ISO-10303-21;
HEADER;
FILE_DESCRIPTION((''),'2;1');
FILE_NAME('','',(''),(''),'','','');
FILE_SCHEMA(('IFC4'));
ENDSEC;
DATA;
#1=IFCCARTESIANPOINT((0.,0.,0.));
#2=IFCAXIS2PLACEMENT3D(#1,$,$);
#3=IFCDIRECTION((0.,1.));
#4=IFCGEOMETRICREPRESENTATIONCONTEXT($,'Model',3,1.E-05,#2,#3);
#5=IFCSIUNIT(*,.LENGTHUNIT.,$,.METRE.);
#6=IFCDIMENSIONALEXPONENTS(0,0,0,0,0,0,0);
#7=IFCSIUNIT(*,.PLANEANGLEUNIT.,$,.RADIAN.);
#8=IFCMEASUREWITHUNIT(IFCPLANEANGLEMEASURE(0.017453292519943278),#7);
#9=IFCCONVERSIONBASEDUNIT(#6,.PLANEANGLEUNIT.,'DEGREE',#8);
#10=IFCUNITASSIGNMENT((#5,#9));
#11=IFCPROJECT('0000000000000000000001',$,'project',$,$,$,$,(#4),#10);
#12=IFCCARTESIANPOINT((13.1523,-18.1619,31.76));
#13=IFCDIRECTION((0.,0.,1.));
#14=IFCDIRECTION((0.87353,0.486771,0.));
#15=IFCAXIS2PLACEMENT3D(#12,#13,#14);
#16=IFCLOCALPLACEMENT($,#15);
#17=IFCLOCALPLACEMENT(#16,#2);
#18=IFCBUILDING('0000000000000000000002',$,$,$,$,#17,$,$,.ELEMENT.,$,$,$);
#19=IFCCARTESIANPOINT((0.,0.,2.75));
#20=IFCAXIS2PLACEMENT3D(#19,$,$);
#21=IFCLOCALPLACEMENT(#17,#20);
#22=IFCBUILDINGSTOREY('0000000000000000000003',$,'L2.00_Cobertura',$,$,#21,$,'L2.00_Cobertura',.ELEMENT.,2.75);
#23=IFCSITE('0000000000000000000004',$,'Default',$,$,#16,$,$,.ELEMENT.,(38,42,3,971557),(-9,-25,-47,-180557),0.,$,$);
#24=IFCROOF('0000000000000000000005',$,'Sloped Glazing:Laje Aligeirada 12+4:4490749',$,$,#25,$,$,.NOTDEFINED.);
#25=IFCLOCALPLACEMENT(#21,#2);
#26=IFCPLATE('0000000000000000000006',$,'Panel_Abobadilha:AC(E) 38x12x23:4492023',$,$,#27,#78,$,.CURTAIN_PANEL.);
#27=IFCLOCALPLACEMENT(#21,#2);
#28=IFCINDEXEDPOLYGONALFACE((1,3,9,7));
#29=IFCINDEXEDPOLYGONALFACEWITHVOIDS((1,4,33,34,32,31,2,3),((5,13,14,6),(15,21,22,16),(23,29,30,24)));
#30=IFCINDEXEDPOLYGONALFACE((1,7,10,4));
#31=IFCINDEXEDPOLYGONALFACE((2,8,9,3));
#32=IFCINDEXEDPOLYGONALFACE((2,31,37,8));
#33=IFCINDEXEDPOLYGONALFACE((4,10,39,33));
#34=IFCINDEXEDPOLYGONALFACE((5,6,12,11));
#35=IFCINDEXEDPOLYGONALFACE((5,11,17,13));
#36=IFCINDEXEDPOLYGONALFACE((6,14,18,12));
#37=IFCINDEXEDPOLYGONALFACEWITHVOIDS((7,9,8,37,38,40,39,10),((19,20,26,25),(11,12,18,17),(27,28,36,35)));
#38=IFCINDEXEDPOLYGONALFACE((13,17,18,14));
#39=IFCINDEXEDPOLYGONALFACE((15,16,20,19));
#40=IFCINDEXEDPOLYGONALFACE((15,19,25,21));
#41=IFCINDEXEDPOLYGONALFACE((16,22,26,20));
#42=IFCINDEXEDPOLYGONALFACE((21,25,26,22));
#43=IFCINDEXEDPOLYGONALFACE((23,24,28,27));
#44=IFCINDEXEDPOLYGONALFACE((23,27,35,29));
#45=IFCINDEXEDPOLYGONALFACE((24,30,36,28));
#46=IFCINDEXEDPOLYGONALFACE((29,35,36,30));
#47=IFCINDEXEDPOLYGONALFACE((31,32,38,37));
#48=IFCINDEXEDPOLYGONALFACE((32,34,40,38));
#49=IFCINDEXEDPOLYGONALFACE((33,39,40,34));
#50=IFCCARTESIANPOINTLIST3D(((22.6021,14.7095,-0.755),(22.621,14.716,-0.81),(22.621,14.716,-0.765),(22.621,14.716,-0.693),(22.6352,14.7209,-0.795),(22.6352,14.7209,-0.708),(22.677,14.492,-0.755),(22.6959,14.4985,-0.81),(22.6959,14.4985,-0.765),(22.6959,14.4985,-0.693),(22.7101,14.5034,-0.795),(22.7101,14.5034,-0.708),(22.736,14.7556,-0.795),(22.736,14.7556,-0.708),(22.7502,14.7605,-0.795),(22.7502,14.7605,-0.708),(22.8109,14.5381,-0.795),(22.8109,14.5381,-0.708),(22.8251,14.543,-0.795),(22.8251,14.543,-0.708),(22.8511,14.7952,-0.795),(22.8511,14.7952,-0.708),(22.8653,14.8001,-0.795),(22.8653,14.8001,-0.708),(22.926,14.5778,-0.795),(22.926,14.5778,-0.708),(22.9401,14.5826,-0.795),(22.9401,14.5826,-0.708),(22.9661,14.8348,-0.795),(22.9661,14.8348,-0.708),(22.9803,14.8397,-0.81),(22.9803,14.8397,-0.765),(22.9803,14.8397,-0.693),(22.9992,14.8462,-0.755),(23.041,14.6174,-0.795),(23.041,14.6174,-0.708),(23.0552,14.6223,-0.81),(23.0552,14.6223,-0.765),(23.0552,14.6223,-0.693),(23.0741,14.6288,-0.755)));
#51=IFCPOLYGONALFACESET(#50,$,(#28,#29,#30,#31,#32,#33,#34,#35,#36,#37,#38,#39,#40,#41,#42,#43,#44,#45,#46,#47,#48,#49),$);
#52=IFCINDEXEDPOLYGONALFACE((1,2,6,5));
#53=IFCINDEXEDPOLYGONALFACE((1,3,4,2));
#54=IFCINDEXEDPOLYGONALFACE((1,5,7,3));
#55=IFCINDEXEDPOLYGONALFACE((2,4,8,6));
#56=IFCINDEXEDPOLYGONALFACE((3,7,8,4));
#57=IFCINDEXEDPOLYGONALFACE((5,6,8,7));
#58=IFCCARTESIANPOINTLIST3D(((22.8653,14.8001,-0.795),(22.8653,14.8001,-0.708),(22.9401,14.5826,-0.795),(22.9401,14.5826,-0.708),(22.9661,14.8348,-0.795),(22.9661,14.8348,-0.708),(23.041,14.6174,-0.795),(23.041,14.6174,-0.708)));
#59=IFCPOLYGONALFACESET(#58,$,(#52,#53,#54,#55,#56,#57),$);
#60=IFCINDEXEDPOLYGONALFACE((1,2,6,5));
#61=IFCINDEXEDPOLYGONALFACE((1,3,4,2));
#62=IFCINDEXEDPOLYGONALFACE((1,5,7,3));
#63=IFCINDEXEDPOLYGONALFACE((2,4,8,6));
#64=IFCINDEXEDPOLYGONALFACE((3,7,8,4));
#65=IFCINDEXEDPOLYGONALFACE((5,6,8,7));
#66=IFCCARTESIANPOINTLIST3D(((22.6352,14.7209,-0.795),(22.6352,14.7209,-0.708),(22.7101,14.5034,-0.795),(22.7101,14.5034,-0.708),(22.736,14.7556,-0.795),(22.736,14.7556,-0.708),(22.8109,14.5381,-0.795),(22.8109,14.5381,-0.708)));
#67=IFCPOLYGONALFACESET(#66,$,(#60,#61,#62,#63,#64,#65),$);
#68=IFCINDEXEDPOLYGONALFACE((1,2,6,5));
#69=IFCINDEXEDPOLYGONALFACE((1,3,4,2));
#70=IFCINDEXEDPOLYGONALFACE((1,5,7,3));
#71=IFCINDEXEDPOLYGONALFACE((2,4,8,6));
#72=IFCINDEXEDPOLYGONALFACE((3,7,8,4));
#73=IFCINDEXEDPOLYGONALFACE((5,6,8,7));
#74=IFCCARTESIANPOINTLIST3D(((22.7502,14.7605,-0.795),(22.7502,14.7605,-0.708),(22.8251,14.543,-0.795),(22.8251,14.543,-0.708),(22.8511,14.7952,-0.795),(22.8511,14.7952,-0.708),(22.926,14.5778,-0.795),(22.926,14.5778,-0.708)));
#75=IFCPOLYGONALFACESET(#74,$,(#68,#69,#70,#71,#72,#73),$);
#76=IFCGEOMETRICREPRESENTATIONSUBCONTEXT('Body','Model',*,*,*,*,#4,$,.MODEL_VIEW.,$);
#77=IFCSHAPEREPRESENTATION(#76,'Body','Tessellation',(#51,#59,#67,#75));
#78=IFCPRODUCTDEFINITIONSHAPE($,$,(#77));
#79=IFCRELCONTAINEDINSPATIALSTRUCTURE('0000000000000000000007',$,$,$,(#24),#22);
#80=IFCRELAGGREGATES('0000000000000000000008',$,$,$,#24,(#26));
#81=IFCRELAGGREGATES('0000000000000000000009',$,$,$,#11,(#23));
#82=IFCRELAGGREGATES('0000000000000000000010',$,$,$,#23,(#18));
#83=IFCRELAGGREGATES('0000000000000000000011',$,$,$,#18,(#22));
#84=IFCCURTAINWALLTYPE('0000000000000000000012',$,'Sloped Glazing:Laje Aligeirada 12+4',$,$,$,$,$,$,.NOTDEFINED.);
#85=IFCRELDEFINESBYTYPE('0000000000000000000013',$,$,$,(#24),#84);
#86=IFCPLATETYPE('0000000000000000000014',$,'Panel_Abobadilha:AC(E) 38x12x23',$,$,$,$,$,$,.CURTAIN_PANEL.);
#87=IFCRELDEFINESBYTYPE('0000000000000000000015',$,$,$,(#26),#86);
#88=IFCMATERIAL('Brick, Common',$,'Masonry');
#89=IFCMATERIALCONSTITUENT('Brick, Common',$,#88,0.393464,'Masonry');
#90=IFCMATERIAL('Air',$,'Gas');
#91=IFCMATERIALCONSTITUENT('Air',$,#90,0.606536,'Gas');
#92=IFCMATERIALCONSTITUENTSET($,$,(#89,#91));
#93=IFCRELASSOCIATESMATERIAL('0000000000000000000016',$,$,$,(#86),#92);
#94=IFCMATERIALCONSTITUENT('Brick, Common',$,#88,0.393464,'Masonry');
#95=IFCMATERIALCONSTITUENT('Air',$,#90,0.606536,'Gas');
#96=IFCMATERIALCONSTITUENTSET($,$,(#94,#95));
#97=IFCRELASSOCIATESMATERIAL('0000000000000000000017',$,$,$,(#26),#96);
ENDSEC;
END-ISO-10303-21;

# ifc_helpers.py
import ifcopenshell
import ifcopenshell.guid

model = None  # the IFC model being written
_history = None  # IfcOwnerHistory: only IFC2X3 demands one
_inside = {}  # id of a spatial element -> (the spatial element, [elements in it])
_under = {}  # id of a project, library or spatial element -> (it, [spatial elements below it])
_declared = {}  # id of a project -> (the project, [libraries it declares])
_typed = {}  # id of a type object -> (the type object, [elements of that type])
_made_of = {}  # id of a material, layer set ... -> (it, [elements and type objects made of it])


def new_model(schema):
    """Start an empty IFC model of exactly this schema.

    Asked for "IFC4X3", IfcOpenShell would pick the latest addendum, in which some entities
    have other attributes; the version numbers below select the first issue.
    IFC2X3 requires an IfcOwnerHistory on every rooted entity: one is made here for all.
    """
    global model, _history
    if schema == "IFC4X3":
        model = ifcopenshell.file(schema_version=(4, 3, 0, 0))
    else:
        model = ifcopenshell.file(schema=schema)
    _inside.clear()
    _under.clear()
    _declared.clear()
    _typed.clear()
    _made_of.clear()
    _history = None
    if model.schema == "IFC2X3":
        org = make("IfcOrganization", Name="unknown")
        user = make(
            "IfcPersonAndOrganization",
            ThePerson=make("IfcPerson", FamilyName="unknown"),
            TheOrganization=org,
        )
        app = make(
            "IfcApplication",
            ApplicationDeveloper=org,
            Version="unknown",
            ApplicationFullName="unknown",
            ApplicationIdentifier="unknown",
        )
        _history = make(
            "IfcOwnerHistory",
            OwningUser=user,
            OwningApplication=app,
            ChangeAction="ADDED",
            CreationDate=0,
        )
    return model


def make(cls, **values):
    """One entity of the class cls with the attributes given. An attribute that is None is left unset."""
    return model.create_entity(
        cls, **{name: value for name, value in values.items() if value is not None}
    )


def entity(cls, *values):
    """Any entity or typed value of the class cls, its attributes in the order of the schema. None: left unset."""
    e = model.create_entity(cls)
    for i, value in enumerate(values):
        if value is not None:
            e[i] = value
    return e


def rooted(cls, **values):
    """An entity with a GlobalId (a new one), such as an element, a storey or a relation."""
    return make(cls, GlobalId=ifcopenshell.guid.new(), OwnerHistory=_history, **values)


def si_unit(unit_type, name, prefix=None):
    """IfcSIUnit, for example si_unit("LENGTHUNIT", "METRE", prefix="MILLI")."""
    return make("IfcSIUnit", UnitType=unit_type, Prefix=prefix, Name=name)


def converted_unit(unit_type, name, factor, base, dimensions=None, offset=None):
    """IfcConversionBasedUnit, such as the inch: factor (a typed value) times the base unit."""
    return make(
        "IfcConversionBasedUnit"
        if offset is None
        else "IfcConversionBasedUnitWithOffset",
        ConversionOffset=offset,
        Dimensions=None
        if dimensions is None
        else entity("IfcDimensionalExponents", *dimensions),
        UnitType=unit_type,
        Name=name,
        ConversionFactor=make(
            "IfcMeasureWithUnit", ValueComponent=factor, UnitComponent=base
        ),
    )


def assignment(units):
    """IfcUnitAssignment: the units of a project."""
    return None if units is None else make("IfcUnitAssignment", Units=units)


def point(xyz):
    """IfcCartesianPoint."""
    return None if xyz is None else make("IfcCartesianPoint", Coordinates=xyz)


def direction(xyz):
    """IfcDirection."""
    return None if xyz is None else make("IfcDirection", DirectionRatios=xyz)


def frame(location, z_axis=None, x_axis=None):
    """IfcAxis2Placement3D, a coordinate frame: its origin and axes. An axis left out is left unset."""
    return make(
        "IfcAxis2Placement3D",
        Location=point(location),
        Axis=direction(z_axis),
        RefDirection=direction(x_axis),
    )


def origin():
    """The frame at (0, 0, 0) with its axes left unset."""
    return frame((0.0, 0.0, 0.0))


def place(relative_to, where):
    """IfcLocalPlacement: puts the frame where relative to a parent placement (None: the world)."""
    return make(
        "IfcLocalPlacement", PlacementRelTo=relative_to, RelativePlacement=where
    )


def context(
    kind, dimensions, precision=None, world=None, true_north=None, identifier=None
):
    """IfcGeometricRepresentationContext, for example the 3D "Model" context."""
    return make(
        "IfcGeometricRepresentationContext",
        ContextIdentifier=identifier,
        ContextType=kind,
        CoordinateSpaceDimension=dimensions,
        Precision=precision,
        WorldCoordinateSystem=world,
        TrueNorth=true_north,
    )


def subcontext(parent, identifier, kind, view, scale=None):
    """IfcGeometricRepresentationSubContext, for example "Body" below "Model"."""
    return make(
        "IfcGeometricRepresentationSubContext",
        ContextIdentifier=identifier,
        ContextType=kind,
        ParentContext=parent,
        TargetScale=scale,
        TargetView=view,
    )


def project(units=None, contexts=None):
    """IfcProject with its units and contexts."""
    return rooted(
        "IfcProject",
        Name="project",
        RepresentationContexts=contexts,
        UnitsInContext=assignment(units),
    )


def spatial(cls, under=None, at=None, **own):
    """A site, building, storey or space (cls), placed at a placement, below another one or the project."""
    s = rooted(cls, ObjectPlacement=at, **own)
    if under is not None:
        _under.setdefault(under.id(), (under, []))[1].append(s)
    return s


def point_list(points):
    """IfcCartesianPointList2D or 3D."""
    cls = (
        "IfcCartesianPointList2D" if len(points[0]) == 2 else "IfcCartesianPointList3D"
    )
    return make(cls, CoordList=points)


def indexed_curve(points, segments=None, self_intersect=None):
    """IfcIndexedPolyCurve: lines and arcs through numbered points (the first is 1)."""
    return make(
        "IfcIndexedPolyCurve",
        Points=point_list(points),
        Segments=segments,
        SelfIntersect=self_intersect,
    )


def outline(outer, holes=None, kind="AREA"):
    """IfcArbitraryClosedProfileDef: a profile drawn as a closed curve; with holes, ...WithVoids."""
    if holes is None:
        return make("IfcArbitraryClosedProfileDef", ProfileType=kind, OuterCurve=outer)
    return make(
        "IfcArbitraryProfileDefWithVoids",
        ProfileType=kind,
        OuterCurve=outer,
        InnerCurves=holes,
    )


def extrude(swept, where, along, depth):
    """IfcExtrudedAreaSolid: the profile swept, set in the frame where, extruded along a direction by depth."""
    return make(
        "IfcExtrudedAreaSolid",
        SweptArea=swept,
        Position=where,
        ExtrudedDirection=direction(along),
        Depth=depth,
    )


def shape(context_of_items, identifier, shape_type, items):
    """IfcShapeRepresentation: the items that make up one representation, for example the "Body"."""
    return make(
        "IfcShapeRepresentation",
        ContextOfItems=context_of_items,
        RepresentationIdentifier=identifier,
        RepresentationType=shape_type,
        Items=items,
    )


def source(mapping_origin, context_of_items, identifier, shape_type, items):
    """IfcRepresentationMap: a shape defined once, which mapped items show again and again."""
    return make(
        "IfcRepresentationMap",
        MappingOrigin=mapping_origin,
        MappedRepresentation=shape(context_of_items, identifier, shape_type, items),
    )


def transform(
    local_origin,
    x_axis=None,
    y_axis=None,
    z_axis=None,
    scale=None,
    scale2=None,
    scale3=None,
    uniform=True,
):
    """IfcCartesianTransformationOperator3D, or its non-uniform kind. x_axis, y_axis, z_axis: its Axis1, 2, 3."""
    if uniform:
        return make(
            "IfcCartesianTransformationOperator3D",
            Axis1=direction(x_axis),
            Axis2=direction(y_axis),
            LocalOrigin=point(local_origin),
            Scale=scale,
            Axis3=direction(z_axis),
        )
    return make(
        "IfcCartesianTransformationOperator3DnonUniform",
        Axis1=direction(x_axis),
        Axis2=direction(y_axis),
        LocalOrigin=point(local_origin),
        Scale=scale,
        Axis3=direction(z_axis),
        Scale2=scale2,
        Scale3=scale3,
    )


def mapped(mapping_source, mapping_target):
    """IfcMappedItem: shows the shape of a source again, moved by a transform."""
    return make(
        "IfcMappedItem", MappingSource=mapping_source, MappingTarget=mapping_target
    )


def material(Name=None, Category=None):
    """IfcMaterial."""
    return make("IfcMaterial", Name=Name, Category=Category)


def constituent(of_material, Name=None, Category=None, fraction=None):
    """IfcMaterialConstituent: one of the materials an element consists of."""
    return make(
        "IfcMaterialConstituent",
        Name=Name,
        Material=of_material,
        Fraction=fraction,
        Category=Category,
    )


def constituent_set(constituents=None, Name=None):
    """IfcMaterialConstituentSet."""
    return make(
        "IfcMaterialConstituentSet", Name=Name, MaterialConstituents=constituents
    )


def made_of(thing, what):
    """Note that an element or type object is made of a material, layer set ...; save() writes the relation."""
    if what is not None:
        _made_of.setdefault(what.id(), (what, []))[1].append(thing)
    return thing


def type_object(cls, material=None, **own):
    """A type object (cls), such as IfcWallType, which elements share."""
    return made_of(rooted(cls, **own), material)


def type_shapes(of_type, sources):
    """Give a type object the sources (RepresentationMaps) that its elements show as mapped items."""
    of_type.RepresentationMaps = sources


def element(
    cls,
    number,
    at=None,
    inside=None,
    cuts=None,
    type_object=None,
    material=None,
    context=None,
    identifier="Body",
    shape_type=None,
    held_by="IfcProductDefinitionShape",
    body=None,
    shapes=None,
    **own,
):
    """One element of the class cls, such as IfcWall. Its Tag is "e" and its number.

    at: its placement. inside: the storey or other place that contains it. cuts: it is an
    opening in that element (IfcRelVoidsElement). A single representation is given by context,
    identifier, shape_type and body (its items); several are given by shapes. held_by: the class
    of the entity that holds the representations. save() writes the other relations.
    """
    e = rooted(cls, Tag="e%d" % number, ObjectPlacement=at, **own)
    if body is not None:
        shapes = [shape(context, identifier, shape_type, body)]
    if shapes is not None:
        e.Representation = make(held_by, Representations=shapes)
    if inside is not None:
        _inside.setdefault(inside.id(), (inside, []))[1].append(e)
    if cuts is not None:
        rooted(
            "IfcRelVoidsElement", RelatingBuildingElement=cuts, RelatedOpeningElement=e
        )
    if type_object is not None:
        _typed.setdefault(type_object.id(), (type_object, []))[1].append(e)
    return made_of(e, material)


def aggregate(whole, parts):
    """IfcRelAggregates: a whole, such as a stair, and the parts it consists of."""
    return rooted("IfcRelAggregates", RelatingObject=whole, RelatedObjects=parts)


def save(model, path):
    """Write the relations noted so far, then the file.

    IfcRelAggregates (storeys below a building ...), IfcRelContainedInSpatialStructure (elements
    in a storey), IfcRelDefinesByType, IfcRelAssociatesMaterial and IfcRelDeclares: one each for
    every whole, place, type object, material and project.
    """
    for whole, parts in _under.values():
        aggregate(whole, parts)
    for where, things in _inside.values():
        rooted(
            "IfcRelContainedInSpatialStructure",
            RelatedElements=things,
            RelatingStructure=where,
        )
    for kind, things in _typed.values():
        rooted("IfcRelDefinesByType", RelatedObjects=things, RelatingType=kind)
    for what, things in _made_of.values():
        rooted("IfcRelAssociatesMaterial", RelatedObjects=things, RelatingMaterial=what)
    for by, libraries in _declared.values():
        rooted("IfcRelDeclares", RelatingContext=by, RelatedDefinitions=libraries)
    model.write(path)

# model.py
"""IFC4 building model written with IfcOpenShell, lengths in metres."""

from ifc_helpers import new_model, entity, si_unit, converted_unit, direction, frame, origin, place, context, subcontext, project, spatial, indexed_curve, outline, extrude, source, transform, mapped, material, constituent, constituent_set, type_object, type_shapes, element, aggregate, save


model = new_model("IFC4")

# Units and contexts
model_context = context("Model", 3, precision=1e-05, world=origin(), true_north=direction((0.0, 1.0)))
body_context = subcontext(model_context, "Body", "Model", "MODEL_VIEW")
ifc_project = project(units=[si_unit("LENGTHUNIT", "METRE"), converted_unit("PLANEANGLEUNIT", "DEGREE", entity("IfcPlaneAngleMeasure", 0.017453292519943278), si_unit("PLANEANGLEUNIT", "RADIAN"), dimensions=[0, 0, 0, 0, 0, 0, 0])], contexts=[model_context])

# Site, building, storey
site_placement = place(None, frame((13.1523, -18.1619, 31.76), z_axis=(0.0, 0.0, 1.0), x_axis=(0.87353, 0.486771, 0.0)))
site = spatial("IfcSite", under=ifc_project, at=site_placement, Name="Default", CompositionType="ELEMENT", RefLatitude=(38, 42, 3, 971557), RefLongitude=(-9, -25, -47, -180557), RefElevation=0.0)
building_placement = place(site_placement, origin())
building = spatial("IfcBuilding", under=site, at=building_placement, CompositionType="ELEMENT")
storey_placement = place(building_placement, frame((0.0, 0.0, 2.75)))
storey = spatial("IfcBuildingStorey", under=building, at=storey_placement, Name="L2.00_Cobertura", LongName="L2.00_Cobertura", CompositionType="ELEMENT", Elevation=2.75)

# Roof, plate
curtain_wall_type = type_object("IfcCurtainWallType", Name="Sloped Glazing:Laje Aligeirada 12+4", PredefinedType="NOTDEFINED")
roof_placement = place(storey_placement, frame((0.0, 0.0, -2.75)))
roof = element("IfcRoof", 1, at=roof_placement, inside=storey, type_object=curtain_wall_type, Name="Sloped Glazing:Laje Aligeirada 12+4:4490749", PredefinedType="NOTDEFINED")
ifc_material_1 = material(Name="Brick, Common", Category="Masonry")
ifc_material_2 = material(Name="Air", Category="Gas")
ifc_constituent_1 = constituent(ifc_material_1, Name="Brick, Common", Category="Masonry", fraction=0.393464)
ifc_constituent_2 = constituent(ifc_material_2, Name="Air", Category="Gas", fraction=0.606536)
ifc_constituent_set_1 = constituent_set(constituents=[ifc_constituent_1, ifc_constituent_2])
plate_type = type_object("IfcPlateType", Name="Panel_Abobadilha:AC(E) 38x12x23", PredefinedType="CURTAIN_PANEL", material=ifc_constituent_set_1)
shared_shape_1 = source(origin(), body_context, "Body", "SweptSolid", [
    extrude(outline(indexed_curve([(-0.19, -0.0543), (0.19, -0.0543), (0.19, -0.0093), (0.21, 0.0007), (0.19, 0.0628), (-0.19, 0.0628), (-0.21, 0.0007), (-0.19, -0.0093), (-0.19, -0.0543)], self_intersect=False), holes=[indexed_curve([(-0.0683, 0.0477), (-0.0683, -0.0393), (-0.175, -0.0393), (-0.175, 0.0477), (-0.0683, 0.0477)], self_intersect=False), indexed_curve([(0.0533, 0.0477), (0.0533, -0.0393), (-0.0533, -0.0393), (-0.0533, 0.0477), (0.0533, 0.0477)], self_intersect=False), indexed_curve([(0.175, 0.0477), (0.175, -0.0393), (0.0683, -0.0393), (0.0683, 0.0477), (0.175, 0.0477)], self_intersect=False)]), frame((0.0, 0.0543, 0.0)), (0.0, 0.0, 1.0), 0.23),
    extrude(outline(indexed_curve([(-0.0533, -0.0435), (0.0533, -0.0435), (0.0533, 0.0435), (-0.0533, 0.0435), (-0.0533, -0.0435)], self_intersect=False)), frame((0.1217, 0.0585, 0.0), z_axis=(0.0, 0.0, 1.0), x_axis=(-1.0, 0.0, 0.0)), (0.0, 0.0, 1.0), 0.23),
    extrude(outline(indexed_curve([(-0.0533, -0.0435), (0.0533, -0.0435), (0.0533, 0.0435), (-0.0533, 0.0435), (-0.0533, -0.0435)], self_intersect=False)), frame((-0.1217, 0.0585, 0.0), z_axis=(0.0, 0.0, 1.0), x_axis=(-1.0, 0.0, 0.0)), (0.0, 0.0, 1.0), 0.23),
    extrude(outline(indexed_curve([(-0.0533, -0.0435), (0.0533, -0.0435), (0.0533, 0.0435), (-0.0533, 0.0435), (-0.0533, -0.0435)], self_intersect=False)), frame((0.0, 0.0585, 0.0), z_axis=(0.0, 0.0, 1.0), x_axis=(-1.0, 0.0, 0.0)), (0.0, 0.0, 1.0), 0.23),
])
type_shapes(plate_type, [shared_shape_1])
ifc_constituent_3 = constituent(ifc_material_1, Name="Brick, Common", Category="Masonry", fraction=0.393464)
ifc_constituent_4 = constituent(ifc_material_2, Name="Air", Category="Gas", fraction=0.606536)
ifc_constituent_set_2 = constituent_set(constituents=[ifc_constituent_3, ifc_constituent_4])
plate_1_placement = place(roof_placement, frame((22.8007, 14.7779, 1.94), z_axis=(0.325568, -0.945519, 0.0), x_axis=(0.945519, 0.325568, 0.0)))
plate_1 = element("IfcPlate", 2, at=plate_1_placement, type_object=plate_type, material=ifc_constituent_set_2, Name="Panel_Abobadilha:AC(E) 38x12x23:4492023", PredefinedType="CURTAIN_PANEL", context=body_context, shape_type="MappedRepresentation", body=[
    mapped(shared_shape_1, transform((0.0, 0.0, 0.0), scale=1.0)),
])
aggregate(roof, [plate_1])

save(model, "model.ifc")
